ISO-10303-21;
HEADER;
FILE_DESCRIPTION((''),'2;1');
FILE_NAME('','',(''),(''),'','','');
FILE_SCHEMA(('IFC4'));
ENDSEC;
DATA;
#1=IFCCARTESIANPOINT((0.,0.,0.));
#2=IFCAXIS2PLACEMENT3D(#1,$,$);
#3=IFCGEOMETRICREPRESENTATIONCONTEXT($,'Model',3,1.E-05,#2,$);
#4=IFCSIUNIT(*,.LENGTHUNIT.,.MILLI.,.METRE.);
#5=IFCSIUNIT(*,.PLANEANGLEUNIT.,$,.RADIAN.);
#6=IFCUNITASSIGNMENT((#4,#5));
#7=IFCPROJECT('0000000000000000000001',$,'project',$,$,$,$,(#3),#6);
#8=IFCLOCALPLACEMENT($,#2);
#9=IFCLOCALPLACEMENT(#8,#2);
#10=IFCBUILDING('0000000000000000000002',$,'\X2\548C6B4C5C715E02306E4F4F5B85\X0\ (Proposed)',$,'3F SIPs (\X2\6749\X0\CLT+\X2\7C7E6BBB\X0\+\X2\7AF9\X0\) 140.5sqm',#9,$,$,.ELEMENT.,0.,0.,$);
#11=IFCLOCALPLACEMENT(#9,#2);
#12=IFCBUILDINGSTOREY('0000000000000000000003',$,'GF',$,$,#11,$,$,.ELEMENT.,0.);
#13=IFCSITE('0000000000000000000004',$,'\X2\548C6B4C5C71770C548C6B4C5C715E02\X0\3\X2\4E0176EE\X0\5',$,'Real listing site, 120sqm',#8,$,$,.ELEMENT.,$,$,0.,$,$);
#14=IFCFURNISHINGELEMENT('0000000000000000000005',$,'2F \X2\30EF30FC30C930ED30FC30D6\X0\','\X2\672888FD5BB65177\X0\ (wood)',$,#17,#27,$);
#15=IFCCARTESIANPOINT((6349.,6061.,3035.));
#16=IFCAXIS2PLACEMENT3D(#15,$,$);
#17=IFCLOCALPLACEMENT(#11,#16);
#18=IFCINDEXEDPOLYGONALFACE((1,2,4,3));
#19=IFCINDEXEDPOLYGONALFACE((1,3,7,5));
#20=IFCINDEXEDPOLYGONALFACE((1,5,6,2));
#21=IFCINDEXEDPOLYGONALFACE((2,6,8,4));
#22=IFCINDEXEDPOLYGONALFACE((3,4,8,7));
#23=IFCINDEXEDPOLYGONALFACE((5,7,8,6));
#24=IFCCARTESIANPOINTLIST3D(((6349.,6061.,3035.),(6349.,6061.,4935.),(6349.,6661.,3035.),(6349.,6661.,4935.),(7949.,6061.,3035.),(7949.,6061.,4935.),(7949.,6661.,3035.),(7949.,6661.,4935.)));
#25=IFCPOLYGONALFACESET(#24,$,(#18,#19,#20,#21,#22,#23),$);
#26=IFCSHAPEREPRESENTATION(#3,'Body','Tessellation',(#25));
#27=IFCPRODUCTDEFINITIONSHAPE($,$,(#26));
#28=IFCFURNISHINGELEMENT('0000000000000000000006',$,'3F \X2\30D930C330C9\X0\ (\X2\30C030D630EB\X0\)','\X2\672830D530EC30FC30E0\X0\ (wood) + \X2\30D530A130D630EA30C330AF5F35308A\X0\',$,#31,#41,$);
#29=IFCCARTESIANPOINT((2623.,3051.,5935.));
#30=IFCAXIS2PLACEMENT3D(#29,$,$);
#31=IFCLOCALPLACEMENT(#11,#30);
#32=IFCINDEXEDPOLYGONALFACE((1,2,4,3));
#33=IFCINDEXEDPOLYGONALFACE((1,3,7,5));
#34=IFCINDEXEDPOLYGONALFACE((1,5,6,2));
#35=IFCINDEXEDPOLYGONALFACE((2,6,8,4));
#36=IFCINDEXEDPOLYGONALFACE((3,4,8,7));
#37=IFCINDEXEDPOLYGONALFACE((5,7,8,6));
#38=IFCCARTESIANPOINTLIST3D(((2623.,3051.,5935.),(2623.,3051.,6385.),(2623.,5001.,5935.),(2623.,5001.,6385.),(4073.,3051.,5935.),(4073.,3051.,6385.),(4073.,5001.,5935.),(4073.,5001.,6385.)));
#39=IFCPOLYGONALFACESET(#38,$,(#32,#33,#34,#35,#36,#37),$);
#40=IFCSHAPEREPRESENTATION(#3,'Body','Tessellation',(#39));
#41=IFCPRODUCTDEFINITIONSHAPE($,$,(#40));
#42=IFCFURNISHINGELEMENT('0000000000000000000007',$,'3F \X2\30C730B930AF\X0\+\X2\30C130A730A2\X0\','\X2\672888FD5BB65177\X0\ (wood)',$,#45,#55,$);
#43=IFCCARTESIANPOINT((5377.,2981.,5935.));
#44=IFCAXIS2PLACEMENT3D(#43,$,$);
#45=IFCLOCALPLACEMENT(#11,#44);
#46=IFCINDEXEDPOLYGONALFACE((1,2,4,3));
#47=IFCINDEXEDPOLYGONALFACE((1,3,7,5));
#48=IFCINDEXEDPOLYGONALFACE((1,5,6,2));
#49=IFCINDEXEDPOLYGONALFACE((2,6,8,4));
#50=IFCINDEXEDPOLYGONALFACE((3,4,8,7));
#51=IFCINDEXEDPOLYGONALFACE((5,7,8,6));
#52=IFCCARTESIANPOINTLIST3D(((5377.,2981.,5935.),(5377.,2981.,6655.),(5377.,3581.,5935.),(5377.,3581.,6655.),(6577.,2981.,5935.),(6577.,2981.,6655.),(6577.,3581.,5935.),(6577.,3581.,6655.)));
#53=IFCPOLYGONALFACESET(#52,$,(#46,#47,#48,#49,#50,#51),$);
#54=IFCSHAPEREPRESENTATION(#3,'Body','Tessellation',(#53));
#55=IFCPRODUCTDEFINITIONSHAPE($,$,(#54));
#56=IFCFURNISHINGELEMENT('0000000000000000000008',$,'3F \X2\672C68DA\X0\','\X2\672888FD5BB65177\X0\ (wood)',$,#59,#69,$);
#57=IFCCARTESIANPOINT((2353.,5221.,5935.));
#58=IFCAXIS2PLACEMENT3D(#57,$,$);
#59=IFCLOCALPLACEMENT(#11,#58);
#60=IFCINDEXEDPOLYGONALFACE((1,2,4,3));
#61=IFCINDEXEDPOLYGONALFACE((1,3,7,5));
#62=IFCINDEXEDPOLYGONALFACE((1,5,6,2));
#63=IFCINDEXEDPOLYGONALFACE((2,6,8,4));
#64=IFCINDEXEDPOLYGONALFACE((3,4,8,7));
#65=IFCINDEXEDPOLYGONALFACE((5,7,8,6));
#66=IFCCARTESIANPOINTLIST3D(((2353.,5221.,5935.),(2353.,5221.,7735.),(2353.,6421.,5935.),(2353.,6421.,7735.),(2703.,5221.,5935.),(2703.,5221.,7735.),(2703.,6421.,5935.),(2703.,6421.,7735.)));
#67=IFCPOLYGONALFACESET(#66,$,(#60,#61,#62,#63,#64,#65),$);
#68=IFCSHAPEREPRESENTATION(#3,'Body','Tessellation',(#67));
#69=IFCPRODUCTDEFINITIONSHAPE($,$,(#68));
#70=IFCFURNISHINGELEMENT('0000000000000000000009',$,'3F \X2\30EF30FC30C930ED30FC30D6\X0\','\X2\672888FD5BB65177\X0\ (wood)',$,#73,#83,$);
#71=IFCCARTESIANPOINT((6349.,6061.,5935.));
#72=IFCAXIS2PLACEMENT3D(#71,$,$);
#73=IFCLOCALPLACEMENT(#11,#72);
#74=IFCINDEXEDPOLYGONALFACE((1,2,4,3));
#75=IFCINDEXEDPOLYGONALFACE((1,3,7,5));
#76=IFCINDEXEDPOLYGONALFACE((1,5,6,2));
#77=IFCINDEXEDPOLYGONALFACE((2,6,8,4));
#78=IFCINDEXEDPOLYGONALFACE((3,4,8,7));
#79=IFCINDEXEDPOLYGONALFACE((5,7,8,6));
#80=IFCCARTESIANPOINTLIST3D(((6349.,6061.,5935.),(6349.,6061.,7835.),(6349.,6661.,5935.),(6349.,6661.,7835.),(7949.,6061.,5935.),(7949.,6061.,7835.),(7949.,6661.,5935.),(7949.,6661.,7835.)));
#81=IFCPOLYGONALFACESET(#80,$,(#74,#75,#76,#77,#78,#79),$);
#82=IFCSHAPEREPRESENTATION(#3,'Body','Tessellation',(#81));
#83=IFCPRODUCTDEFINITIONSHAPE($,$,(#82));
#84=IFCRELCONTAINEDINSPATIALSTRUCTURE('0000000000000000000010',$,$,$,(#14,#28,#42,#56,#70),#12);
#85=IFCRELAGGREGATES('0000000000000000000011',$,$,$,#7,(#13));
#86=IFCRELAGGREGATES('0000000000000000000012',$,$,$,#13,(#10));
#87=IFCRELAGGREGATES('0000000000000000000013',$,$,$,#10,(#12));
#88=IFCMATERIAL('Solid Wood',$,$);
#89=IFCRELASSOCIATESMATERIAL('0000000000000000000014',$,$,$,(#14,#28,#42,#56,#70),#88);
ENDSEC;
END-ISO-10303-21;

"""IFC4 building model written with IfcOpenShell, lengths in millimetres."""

from ifc_helpers import new_model, si_unit, frame, frame_2d, origin, place, context, project, spatial, rectangle, extrude, material, element, save


model = new_model("IFC4")

# Units and contexts
model_context = context("Model", 3, precision=1e-05, world=origin())
ifc_project = project(units=[si_unit("LENGTHUNIT", "METRE", prefix="MILLI"), si_unit("PLANEANGLEUNIT", "RADIAN")], contexts=[model_context])

# Site, building, storey
site_placement = place(None, origin())
site = spatial("IfcSite", under=ifc_project, at=site_placement, Name="和歌山県和歌山市3丁目5", ObjectType="Real listing site, 120sqm", CompositionType="ELEMENT", RefElevation=0.0)
building_placement = place(site_placement, origin())
building = spatial("IfcBuilding", under=site, at=building_placement, Name="和歌山市の住宅 (Proposed)", ObjectType="3F SIPs (杉CLT+籾殻+竹) 140.5sqm", CompositionType="ELEMENT", ElevationOfRefHeight=0.0, ElevationOfTerrain=0.0)
storey_placement = place(building_placement, origin())
storey = spatial("IfcBuildingStorey", under=building, at=storey_placement, Name="GF", CompositionType="ELEMENT", Elevation=0.0)

# Shared definitions
ifc_material_1 = material(Name="Solid Wood")

# Furnishing elements
furnishing_1_placement = place(storey_placement, frame((6349.0, 6061.0, 3035.0)))
element("IfcFurnishingElement", 1, at=furnishing_1_placement, inside=storey, material=ifc_material_1, Name="2F ワードローブ", Description="木製家具 (wood)", context=model_context, shape_type="SweptSolid", body=[
    extrude(rectangle(XDim=1600.0, YDim=600.0, at=frame_2d((800.0, 300.0))), frame((6349.0, 6061.0, 3035.0)), (0.0, 0.0, 1.0), 1900.0),
])
furnishing_2_placement = place(storey_placement, frame((2623.0, 3051.0, 5935.0)))
element("IfcFurnishingElement", 2, at=furnishing_2_placement, inside=storey, material=ifc_material_1, Name="3F ベッド (ダブル)", Description="木フレーム (wood) + ファブリック張り", context=model_context, shape_type="SweptSolid", body=[
    extrude(rectangle(XDim=1450.0, YDim=1950.0, at=frame_2d((725.0, 975.0))), frame((2623.0, 3051.0, 5935.0)), (0.0, 0.0, 1.0), 450.0),
])
furnishing_3_placement = place(storey_placement, frame((5377.0, 2981.0, 5935.0)))
element("IfcFurnishingElement", 3, at=furnishing_3_placement, inside=storey, material=ifc_material_1, Name="3F デスク+チェア", Description="木製家具 (wood)", context=model_context, shape_type="SweptSolid", body=[
    extrude(rectangle(XDim=1200.0, YDim=600.0, at=frame_2d((600.0, 300.0))), frame((5377.0, 2981.0, 5935.0)), (0.0, 0.0, 1.0), 720.0),
])
furnishing_4_placement = place(storey_placement, frame((2353.0, 5221.0, 5935.0)))
element("IfcFurnishingElement", 4, at=furnishing_4_placement, inside=storey, material=ifc_material_1, Name="3F 本棚", Description="木製家具 (wood)", context=model_context, shape_type="SweptSolid", body=[
    extrude(rectangle(XDim=350.0, YDim=1200.0, at=frame_2d((175.0, 600.0))), frame((2353.0, 5221.0, 5935.0)), (0.0, 0.0, 1.0), 1800.0),
])
furnishing_5_placement = place(storey_placement, frame((6349.0, 6061.0, 5935.0)))
element("IfcFurnishingElement", 5, at=furnishing_5_placement, inside=storey, material=ifc_material_1, Name="3F ワードローブ", Description="木製家具 (wood)", context=model_context, shape_type="SweptSolid", body=[
    extrude(rectangle(XDim=1600.0, YDim=600.0, at=frame_2d((800.0, 300.0))), frame((6349.0, 6061.0, 5935.0)), (0.0, 0.0, 1.0), 1900.0),
])

save(model, "model.ifc")
